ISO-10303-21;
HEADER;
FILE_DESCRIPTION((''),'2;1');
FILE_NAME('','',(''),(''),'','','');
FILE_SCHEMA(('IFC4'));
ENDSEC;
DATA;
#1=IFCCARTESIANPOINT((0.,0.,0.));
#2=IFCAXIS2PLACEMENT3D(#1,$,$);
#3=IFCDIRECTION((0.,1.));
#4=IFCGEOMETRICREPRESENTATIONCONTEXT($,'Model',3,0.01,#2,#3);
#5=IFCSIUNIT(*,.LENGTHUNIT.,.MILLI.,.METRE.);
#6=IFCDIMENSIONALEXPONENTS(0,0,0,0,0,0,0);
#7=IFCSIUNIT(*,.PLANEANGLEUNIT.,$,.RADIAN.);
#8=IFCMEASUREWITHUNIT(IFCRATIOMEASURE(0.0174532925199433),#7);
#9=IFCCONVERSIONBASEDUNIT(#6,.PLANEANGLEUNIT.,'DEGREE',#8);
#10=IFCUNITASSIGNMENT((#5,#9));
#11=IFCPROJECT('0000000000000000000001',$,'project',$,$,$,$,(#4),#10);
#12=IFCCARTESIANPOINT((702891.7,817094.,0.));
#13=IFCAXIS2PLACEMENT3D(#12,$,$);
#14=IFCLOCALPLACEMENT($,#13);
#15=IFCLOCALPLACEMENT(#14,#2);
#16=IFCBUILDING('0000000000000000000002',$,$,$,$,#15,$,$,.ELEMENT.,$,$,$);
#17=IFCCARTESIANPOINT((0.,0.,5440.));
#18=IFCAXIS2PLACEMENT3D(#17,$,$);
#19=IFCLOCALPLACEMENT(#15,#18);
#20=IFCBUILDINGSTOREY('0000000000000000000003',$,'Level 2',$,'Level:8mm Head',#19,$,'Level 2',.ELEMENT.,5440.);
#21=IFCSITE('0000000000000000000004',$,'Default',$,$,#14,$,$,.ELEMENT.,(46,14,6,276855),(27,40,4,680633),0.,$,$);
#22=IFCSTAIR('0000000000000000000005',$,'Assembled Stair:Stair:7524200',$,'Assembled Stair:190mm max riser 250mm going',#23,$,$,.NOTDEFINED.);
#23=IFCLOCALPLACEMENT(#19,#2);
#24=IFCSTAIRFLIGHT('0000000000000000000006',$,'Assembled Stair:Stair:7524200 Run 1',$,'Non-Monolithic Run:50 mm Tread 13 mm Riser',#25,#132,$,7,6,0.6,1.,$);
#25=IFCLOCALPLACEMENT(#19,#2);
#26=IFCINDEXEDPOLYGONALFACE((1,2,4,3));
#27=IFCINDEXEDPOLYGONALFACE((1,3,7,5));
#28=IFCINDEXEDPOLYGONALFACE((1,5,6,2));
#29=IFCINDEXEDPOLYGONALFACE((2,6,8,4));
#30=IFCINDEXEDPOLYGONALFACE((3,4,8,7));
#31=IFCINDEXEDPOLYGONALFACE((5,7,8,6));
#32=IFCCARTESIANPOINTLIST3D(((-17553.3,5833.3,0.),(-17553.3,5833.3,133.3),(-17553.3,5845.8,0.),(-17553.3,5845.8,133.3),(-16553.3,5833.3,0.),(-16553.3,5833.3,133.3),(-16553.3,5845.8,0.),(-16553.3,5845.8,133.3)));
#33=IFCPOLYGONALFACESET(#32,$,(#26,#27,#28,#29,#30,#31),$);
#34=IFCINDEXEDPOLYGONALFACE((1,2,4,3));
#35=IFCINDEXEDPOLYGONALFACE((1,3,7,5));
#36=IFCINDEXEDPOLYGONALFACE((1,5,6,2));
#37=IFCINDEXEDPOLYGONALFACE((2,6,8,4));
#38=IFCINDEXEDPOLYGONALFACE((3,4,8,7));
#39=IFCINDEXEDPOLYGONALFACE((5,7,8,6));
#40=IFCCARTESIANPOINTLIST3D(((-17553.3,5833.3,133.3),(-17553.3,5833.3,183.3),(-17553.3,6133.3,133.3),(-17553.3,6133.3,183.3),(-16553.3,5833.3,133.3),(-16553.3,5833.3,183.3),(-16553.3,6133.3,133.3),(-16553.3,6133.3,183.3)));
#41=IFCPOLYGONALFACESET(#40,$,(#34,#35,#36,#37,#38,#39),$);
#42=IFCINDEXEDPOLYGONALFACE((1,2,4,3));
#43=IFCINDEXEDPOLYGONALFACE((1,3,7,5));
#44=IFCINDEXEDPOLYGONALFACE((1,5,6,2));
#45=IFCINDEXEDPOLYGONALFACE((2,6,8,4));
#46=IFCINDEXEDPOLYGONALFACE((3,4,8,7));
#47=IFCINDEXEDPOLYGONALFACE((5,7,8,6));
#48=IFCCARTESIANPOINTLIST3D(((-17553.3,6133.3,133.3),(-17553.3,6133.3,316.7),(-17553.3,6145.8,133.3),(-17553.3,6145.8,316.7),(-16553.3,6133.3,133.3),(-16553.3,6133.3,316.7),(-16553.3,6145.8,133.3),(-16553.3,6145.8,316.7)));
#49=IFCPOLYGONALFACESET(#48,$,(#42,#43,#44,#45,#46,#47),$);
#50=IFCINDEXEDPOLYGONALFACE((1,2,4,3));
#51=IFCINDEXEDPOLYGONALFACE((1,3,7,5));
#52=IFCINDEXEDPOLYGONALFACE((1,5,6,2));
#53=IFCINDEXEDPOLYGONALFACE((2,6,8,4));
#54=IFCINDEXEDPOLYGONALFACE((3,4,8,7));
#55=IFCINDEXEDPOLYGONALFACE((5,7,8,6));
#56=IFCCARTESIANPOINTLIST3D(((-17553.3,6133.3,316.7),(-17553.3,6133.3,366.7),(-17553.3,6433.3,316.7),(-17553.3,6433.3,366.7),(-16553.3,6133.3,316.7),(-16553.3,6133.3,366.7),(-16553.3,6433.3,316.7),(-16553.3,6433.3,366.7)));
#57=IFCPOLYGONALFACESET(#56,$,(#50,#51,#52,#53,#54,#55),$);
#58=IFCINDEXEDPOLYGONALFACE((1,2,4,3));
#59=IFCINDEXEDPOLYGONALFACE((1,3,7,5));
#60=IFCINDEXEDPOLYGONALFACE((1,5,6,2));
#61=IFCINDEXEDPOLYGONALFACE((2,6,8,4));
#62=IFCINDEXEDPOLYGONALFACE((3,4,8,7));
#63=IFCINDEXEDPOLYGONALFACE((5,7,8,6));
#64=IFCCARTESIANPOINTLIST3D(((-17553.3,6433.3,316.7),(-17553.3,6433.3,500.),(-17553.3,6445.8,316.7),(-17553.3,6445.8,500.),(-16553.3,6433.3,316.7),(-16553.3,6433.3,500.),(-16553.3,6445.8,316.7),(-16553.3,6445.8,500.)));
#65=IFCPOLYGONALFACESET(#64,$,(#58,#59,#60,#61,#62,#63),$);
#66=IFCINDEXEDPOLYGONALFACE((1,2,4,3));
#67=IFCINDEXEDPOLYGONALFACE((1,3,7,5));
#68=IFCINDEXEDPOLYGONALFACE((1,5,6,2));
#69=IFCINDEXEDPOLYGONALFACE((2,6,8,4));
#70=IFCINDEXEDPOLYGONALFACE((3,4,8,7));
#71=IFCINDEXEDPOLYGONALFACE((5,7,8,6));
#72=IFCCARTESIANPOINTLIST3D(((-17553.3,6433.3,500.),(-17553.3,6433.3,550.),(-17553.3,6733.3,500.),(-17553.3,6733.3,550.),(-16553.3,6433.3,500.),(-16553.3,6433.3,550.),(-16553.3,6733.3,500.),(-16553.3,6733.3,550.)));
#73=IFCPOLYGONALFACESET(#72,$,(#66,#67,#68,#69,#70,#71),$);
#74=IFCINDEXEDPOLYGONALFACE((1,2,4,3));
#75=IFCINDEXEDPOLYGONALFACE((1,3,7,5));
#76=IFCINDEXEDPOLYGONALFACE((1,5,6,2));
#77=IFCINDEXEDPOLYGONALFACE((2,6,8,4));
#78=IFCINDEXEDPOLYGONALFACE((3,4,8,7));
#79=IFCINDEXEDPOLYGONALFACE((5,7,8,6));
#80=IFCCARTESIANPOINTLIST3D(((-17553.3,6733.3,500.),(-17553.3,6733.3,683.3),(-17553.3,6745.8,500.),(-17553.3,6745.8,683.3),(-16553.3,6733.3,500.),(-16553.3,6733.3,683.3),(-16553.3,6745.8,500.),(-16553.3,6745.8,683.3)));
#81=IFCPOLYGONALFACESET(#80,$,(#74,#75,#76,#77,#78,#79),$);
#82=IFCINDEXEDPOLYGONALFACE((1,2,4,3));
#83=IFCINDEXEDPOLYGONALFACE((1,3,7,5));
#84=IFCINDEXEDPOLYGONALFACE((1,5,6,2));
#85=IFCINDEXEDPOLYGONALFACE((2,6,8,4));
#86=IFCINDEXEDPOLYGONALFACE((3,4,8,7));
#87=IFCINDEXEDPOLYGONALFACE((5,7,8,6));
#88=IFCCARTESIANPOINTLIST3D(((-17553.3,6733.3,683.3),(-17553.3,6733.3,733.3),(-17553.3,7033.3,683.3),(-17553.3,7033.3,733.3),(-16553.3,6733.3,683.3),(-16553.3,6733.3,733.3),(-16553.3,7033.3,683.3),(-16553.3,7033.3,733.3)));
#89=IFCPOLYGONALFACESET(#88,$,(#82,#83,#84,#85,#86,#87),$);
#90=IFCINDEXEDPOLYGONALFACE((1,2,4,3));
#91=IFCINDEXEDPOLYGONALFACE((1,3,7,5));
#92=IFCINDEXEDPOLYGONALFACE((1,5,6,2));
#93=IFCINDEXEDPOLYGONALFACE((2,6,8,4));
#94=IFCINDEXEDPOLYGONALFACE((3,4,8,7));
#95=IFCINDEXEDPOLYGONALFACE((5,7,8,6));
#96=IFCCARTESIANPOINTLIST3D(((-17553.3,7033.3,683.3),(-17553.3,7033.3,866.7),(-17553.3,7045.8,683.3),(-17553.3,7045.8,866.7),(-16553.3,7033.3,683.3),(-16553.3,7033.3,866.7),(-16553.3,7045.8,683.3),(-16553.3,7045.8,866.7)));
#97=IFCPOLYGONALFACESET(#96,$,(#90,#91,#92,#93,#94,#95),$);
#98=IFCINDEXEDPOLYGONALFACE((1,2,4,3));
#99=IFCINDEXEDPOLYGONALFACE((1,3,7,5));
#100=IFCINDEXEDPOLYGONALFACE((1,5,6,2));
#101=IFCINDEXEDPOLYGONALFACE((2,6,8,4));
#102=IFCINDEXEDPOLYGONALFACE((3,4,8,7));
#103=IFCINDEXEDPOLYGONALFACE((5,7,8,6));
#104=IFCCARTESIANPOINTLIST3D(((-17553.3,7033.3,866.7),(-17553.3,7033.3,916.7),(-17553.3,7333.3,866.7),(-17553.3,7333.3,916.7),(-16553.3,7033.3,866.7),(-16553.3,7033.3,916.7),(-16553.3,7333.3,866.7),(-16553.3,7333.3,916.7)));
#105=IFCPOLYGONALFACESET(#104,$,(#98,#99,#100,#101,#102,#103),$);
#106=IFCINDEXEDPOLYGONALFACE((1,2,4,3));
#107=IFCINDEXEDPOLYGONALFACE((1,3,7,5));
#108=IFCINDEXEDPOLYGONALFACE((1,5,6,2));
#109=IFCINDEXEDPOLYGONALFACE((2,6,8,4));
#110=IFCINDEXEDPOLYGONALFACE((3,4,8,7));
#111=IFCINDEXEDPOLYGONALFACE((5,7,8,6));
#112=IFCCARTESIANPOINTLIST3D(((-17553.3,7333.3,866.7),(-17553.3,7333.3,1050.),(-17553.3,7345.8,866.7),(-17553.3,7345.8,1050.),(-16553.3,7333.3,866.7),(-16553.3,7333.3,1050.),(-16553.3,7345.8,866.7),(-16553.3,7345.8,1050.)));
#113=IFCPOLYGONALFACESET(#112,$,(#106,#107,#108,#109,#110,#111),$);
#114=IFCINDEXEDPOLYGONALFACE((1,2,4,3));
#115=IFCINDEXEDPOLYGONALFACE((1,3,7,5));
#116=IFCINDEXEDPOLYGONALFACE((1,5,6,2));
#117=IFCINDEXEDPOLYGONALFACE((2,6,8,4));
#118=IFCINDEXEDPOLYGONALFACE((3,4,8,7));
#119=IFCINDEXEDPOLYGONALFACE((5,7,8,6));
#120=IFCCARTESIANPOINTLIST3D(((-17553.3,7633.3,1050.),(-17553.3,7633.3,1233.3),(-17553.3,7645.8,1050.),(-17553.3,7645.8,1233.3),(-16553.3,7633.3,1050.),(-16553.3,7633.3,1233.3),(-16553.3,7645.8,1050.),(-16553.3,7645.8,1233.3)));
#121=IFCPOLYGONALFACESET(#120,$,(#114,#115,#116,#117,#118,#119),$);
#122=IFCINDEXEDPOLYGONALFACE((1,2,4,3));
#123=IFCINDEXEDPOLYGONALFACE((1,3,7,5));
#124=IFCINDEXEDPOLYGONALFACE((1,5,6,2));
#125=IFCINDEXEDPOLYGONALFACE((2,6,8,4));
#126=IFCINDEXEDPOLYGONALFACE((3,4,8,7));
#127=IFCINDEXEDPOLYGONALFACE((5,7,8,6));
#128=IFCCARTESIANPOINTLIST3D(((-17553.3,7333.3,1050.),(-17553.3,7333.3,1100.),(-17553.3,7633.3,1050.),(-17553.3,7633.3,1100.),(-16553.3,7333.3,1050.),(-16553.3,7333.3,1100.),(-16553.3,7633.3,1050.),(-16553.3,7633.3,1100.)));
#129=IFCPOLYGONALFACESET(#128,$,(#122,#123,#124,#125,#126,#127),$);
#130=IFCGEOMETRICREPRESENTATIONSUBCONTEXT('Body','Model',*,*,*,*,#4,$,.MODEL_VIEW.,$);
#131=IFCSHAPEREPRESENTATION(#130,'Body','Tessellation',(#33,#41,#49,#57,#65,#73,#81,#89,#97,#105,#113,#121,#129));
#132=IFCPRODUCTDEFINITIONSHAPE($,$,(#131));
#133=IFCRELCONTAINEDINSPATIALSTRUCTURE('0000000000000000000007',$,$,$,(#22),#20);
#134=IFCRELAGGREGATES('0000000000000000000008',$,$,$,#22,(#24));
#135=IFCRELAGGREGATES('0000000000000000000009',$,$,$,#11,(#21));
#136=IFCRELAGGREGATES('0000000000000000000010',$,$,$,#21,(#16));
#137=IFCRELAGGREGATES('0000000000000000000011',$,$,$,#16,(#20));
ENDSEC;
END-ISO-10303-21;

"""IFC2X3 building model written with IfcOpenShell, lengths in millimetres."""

from ifc_helpers import new_model, entity, si_unit, converted_unit, direction, frame, frame_2d, origin, place, context, subcontext, project, spatial, rectangle, extrude, element, aggregate, save


model = new_model("IFC2X3")

# Units and contexts
model_context = context("Model", 3, precision=0.01, world=origin(), true_north=direction((0.0, 1.0)))
body_context = subcontext(model_context, "Body", "Model", "MODEL_VIEW")
ifc_project = project(units=[si_unit("LENGTHUNIT", "METRE", prefix="MILLI"), converted_unit("PLANEANGLEUNIT", "DEGREE", entity("IfcRatioMeasure", 0.0174532925199433), si_unit("PLANEANGLEUNIT", "RADIAN"), dimensions=[0, 0, 0, 0, 0, 0, 0])], contexts=[model_context])

# Site, building, storey
site_placement = place(None, frame((702891.7, 817094.0, 0.0)))
site = spatial("IfcSite", under=ifc_project, at=site_placement, Name="Default", CompositionType="ELEMENT", RefLatitude=(46, 14, 6, 276855), RefLongitude=(27, 40, 4, 680633), RefElevation=0.0)
building_placement = place(site_placement, origin())
building = spatial("IfcBuilding", under=site, at=building_placement, CompositionType="ELEMENT")
storey_placement = place(building_placement, frame((0.0, 0.0, 5440.0)))
storey = spatial("IfcBuildingStorey", under=building, at=storey_placement, Name="Level 2", ObjectType="Level:8mm Head", LongName="Level 2", CompositionType="ELEMENT", Elevation=5440.0)

# Stair
stair_1_placement = place(storey_placement, origin())
stair_1 = element("IfcStair", 1, at=stair_1_placement, inside=storey, Name="Assembled Stair:Stair:7524200", ObjectType="Assembled Stair:190mm max riser 250mm going", ShapeType="NOTDEFINED")

# Stair flight
stair_flight_1_placement = place(stair_1_placement, origin())
stair_flight_1 = element("IfcStairFlight", 2, at=stair_flight_1_placement, Name="Assembled Stair:Stair:7524200 Run 1", ObjectType="Non-Monolithic Run:50 mm Tread 13 mm Riser", NumberOfRiser=7, NumberOfTreads=6, RiserHeight=0.6, TreadLength=1.0, context=body_context, shape_type="SweptSolid", body=[
    extrude(rectangle(XDim=1000.0, YDim=12.5, at=frame_2d((0.0, 0.0), x_axis=(1.0, 0.0))), frame((-17053.3, 5839.6, 0.0), z_axis=(0.0, 0.0, 1.0), x_axis=(-1.0, 0.0, 0.0)), (0.0, 0.0, 1.0), 133.3),
    extrude(rectangle(XDim=300.0, YDim=1000.0, at=frame_2d((0.0, 0.0), x_axis=(1.0, 0.0))), frame((-17053.3, 5983.3, 133.3), z_axis=(0.0, 0.0, 1.0), x_axis=(0.0, -1.0, 0.0)), (0.0, 0.0, 1.0), 50.0),
    extrude(rectangle(XDim=1000.0, YDim=12.5, at=frame_2d((0.0, 0.0), x_axis=(1.0, 0.0))), frame((-17053.3, 6139.6, 133.3), z_axis=(0.0, 0.0, 1.0), x_axis=(-1.0, 0.0, 0.0)), (0.0, 0.0, 1.0), 183.3),
    extrude(rectangle(XDim=300.0, YDim=1000.0, at=frame_2d((0.0, 0.0), x_axis=(1.0, 0.0))), frame((-17053.3, 6283.3, 316.7), z_axis=(0.0, 0.0, 1.0), x_axis=(0.0, -1.0, 0.0)), (0.0, 0.0, 1.0), 50.0),
    extrude(rectangle(XDim=1000.0, YDim=12.5, at=frame_2d((0.0, 0.0), x_axis=(1.0, 0.0))), frame((-17053.3, 6439.6, 316.7), z_axis=(0.0, 0.0, 1.0), x_axis=(-1.0, 0.0, 0.0)), (0.0, 0.0, 1.0), 183.3),
    extrude(rectangle(XDim=300.0, YDim=1000.0, at=frame_2d((0.0, 0.0), x_axis=(1.0, 0.0))), frame((-17053.3, 6583.3, 500.0), z_axis=(0.0, 0.0, 1.0), x_axis=(0.0, -1.0, 0.0)), (0.0, 0.0, 1.0), 50.0),
    extrude(rectangle(XDim=1000.0, YDim=12.5, at=frame_2d((0.0, 0.0), x_axis=(1.0, 0.0))), frame((-17053.3, 6739.6, 500.0), z_axis=(0.0, 0.0, 1.0), x_axis=(-1.0, 0.0, 0.0)), (0.0, 0.0, 1.0), 183.3),
    extrude(rectangle(XDim=300.0, YDim=1000.0, at=frame_2d((0.0, 0.0), x_axis=(1.0, 0.0))), frame((-17053.3, 6883.3, 683.3), z_axis=(0.0, 0.0, 1.0), x_axis=(0.0, -1.0, 0.0)), (0.0, 0.0, 1.0), 50.0),
    extrude(rectangle(XDim=1000.0, YDim=12.5, at=frame_2d((0.0, 0.0), x_axis=(1.0, 0.0))), frame((-17053.3, 7039.6, 683.3), z_axis=(0.0, 0.0, 1.0), x_axis=(-1.0, 0.0, 0.0)), (0.0, 0.0, 1.0), 183.3),
    extrude(rectangle(XDim=300.0, YDim=1000.0, at=frame_2d((0.0, 0.0), x_axis=(1.0, 0.0))), frame((-17053.3, 7183.3, 866.7), z_axis=(0.0, 0.0, 1.0), x_axis=(0.0, -1.0, 0.0)), (0.0, 0.0, 1.0), 50.0),
    extrude(rectangle(XDim=1000.0, YDim=12.5, at=frame_2d((0.0, 0.0), x_axis=(1.0, 0.0))), frame((-17053.3, 7339.6, 866.7), z_axis=(0.0, 0.0, 1.0), x_axis=(-1.0, 0.0, 0.0)), (0.0, 0.0, 1.0), 183.3),
    extrude(rectangle(XDim=1000.0, YDim=12.5, at=frame_2d((0.0, 0.0), x_axis=(1.0, 0.0))), frame((-17053.3, 7639.6, 1050.0), z_axis=(0.0, 0.0, 1.0), x_axis=(-1.0, 0.0, 0.0)), (0.0, 0.0, 1.0), 183.3),
    extrude(rectangle(XDim=300.0, YDim=1000.0, at=frame_2d((0.0, 0.0), x_axis=(1.0, 0.0))), frame((-17053.3, 7483.3, 1050.0), z_axis=(0.0, 0.0, 1.0), x_axis=(0.0, -1.0, 0.0)), (0.0, 0.0, 1.0), 50.0),
])
aggregate(stair_1, [stair_flight_1])

save(model, "model.ifc")
